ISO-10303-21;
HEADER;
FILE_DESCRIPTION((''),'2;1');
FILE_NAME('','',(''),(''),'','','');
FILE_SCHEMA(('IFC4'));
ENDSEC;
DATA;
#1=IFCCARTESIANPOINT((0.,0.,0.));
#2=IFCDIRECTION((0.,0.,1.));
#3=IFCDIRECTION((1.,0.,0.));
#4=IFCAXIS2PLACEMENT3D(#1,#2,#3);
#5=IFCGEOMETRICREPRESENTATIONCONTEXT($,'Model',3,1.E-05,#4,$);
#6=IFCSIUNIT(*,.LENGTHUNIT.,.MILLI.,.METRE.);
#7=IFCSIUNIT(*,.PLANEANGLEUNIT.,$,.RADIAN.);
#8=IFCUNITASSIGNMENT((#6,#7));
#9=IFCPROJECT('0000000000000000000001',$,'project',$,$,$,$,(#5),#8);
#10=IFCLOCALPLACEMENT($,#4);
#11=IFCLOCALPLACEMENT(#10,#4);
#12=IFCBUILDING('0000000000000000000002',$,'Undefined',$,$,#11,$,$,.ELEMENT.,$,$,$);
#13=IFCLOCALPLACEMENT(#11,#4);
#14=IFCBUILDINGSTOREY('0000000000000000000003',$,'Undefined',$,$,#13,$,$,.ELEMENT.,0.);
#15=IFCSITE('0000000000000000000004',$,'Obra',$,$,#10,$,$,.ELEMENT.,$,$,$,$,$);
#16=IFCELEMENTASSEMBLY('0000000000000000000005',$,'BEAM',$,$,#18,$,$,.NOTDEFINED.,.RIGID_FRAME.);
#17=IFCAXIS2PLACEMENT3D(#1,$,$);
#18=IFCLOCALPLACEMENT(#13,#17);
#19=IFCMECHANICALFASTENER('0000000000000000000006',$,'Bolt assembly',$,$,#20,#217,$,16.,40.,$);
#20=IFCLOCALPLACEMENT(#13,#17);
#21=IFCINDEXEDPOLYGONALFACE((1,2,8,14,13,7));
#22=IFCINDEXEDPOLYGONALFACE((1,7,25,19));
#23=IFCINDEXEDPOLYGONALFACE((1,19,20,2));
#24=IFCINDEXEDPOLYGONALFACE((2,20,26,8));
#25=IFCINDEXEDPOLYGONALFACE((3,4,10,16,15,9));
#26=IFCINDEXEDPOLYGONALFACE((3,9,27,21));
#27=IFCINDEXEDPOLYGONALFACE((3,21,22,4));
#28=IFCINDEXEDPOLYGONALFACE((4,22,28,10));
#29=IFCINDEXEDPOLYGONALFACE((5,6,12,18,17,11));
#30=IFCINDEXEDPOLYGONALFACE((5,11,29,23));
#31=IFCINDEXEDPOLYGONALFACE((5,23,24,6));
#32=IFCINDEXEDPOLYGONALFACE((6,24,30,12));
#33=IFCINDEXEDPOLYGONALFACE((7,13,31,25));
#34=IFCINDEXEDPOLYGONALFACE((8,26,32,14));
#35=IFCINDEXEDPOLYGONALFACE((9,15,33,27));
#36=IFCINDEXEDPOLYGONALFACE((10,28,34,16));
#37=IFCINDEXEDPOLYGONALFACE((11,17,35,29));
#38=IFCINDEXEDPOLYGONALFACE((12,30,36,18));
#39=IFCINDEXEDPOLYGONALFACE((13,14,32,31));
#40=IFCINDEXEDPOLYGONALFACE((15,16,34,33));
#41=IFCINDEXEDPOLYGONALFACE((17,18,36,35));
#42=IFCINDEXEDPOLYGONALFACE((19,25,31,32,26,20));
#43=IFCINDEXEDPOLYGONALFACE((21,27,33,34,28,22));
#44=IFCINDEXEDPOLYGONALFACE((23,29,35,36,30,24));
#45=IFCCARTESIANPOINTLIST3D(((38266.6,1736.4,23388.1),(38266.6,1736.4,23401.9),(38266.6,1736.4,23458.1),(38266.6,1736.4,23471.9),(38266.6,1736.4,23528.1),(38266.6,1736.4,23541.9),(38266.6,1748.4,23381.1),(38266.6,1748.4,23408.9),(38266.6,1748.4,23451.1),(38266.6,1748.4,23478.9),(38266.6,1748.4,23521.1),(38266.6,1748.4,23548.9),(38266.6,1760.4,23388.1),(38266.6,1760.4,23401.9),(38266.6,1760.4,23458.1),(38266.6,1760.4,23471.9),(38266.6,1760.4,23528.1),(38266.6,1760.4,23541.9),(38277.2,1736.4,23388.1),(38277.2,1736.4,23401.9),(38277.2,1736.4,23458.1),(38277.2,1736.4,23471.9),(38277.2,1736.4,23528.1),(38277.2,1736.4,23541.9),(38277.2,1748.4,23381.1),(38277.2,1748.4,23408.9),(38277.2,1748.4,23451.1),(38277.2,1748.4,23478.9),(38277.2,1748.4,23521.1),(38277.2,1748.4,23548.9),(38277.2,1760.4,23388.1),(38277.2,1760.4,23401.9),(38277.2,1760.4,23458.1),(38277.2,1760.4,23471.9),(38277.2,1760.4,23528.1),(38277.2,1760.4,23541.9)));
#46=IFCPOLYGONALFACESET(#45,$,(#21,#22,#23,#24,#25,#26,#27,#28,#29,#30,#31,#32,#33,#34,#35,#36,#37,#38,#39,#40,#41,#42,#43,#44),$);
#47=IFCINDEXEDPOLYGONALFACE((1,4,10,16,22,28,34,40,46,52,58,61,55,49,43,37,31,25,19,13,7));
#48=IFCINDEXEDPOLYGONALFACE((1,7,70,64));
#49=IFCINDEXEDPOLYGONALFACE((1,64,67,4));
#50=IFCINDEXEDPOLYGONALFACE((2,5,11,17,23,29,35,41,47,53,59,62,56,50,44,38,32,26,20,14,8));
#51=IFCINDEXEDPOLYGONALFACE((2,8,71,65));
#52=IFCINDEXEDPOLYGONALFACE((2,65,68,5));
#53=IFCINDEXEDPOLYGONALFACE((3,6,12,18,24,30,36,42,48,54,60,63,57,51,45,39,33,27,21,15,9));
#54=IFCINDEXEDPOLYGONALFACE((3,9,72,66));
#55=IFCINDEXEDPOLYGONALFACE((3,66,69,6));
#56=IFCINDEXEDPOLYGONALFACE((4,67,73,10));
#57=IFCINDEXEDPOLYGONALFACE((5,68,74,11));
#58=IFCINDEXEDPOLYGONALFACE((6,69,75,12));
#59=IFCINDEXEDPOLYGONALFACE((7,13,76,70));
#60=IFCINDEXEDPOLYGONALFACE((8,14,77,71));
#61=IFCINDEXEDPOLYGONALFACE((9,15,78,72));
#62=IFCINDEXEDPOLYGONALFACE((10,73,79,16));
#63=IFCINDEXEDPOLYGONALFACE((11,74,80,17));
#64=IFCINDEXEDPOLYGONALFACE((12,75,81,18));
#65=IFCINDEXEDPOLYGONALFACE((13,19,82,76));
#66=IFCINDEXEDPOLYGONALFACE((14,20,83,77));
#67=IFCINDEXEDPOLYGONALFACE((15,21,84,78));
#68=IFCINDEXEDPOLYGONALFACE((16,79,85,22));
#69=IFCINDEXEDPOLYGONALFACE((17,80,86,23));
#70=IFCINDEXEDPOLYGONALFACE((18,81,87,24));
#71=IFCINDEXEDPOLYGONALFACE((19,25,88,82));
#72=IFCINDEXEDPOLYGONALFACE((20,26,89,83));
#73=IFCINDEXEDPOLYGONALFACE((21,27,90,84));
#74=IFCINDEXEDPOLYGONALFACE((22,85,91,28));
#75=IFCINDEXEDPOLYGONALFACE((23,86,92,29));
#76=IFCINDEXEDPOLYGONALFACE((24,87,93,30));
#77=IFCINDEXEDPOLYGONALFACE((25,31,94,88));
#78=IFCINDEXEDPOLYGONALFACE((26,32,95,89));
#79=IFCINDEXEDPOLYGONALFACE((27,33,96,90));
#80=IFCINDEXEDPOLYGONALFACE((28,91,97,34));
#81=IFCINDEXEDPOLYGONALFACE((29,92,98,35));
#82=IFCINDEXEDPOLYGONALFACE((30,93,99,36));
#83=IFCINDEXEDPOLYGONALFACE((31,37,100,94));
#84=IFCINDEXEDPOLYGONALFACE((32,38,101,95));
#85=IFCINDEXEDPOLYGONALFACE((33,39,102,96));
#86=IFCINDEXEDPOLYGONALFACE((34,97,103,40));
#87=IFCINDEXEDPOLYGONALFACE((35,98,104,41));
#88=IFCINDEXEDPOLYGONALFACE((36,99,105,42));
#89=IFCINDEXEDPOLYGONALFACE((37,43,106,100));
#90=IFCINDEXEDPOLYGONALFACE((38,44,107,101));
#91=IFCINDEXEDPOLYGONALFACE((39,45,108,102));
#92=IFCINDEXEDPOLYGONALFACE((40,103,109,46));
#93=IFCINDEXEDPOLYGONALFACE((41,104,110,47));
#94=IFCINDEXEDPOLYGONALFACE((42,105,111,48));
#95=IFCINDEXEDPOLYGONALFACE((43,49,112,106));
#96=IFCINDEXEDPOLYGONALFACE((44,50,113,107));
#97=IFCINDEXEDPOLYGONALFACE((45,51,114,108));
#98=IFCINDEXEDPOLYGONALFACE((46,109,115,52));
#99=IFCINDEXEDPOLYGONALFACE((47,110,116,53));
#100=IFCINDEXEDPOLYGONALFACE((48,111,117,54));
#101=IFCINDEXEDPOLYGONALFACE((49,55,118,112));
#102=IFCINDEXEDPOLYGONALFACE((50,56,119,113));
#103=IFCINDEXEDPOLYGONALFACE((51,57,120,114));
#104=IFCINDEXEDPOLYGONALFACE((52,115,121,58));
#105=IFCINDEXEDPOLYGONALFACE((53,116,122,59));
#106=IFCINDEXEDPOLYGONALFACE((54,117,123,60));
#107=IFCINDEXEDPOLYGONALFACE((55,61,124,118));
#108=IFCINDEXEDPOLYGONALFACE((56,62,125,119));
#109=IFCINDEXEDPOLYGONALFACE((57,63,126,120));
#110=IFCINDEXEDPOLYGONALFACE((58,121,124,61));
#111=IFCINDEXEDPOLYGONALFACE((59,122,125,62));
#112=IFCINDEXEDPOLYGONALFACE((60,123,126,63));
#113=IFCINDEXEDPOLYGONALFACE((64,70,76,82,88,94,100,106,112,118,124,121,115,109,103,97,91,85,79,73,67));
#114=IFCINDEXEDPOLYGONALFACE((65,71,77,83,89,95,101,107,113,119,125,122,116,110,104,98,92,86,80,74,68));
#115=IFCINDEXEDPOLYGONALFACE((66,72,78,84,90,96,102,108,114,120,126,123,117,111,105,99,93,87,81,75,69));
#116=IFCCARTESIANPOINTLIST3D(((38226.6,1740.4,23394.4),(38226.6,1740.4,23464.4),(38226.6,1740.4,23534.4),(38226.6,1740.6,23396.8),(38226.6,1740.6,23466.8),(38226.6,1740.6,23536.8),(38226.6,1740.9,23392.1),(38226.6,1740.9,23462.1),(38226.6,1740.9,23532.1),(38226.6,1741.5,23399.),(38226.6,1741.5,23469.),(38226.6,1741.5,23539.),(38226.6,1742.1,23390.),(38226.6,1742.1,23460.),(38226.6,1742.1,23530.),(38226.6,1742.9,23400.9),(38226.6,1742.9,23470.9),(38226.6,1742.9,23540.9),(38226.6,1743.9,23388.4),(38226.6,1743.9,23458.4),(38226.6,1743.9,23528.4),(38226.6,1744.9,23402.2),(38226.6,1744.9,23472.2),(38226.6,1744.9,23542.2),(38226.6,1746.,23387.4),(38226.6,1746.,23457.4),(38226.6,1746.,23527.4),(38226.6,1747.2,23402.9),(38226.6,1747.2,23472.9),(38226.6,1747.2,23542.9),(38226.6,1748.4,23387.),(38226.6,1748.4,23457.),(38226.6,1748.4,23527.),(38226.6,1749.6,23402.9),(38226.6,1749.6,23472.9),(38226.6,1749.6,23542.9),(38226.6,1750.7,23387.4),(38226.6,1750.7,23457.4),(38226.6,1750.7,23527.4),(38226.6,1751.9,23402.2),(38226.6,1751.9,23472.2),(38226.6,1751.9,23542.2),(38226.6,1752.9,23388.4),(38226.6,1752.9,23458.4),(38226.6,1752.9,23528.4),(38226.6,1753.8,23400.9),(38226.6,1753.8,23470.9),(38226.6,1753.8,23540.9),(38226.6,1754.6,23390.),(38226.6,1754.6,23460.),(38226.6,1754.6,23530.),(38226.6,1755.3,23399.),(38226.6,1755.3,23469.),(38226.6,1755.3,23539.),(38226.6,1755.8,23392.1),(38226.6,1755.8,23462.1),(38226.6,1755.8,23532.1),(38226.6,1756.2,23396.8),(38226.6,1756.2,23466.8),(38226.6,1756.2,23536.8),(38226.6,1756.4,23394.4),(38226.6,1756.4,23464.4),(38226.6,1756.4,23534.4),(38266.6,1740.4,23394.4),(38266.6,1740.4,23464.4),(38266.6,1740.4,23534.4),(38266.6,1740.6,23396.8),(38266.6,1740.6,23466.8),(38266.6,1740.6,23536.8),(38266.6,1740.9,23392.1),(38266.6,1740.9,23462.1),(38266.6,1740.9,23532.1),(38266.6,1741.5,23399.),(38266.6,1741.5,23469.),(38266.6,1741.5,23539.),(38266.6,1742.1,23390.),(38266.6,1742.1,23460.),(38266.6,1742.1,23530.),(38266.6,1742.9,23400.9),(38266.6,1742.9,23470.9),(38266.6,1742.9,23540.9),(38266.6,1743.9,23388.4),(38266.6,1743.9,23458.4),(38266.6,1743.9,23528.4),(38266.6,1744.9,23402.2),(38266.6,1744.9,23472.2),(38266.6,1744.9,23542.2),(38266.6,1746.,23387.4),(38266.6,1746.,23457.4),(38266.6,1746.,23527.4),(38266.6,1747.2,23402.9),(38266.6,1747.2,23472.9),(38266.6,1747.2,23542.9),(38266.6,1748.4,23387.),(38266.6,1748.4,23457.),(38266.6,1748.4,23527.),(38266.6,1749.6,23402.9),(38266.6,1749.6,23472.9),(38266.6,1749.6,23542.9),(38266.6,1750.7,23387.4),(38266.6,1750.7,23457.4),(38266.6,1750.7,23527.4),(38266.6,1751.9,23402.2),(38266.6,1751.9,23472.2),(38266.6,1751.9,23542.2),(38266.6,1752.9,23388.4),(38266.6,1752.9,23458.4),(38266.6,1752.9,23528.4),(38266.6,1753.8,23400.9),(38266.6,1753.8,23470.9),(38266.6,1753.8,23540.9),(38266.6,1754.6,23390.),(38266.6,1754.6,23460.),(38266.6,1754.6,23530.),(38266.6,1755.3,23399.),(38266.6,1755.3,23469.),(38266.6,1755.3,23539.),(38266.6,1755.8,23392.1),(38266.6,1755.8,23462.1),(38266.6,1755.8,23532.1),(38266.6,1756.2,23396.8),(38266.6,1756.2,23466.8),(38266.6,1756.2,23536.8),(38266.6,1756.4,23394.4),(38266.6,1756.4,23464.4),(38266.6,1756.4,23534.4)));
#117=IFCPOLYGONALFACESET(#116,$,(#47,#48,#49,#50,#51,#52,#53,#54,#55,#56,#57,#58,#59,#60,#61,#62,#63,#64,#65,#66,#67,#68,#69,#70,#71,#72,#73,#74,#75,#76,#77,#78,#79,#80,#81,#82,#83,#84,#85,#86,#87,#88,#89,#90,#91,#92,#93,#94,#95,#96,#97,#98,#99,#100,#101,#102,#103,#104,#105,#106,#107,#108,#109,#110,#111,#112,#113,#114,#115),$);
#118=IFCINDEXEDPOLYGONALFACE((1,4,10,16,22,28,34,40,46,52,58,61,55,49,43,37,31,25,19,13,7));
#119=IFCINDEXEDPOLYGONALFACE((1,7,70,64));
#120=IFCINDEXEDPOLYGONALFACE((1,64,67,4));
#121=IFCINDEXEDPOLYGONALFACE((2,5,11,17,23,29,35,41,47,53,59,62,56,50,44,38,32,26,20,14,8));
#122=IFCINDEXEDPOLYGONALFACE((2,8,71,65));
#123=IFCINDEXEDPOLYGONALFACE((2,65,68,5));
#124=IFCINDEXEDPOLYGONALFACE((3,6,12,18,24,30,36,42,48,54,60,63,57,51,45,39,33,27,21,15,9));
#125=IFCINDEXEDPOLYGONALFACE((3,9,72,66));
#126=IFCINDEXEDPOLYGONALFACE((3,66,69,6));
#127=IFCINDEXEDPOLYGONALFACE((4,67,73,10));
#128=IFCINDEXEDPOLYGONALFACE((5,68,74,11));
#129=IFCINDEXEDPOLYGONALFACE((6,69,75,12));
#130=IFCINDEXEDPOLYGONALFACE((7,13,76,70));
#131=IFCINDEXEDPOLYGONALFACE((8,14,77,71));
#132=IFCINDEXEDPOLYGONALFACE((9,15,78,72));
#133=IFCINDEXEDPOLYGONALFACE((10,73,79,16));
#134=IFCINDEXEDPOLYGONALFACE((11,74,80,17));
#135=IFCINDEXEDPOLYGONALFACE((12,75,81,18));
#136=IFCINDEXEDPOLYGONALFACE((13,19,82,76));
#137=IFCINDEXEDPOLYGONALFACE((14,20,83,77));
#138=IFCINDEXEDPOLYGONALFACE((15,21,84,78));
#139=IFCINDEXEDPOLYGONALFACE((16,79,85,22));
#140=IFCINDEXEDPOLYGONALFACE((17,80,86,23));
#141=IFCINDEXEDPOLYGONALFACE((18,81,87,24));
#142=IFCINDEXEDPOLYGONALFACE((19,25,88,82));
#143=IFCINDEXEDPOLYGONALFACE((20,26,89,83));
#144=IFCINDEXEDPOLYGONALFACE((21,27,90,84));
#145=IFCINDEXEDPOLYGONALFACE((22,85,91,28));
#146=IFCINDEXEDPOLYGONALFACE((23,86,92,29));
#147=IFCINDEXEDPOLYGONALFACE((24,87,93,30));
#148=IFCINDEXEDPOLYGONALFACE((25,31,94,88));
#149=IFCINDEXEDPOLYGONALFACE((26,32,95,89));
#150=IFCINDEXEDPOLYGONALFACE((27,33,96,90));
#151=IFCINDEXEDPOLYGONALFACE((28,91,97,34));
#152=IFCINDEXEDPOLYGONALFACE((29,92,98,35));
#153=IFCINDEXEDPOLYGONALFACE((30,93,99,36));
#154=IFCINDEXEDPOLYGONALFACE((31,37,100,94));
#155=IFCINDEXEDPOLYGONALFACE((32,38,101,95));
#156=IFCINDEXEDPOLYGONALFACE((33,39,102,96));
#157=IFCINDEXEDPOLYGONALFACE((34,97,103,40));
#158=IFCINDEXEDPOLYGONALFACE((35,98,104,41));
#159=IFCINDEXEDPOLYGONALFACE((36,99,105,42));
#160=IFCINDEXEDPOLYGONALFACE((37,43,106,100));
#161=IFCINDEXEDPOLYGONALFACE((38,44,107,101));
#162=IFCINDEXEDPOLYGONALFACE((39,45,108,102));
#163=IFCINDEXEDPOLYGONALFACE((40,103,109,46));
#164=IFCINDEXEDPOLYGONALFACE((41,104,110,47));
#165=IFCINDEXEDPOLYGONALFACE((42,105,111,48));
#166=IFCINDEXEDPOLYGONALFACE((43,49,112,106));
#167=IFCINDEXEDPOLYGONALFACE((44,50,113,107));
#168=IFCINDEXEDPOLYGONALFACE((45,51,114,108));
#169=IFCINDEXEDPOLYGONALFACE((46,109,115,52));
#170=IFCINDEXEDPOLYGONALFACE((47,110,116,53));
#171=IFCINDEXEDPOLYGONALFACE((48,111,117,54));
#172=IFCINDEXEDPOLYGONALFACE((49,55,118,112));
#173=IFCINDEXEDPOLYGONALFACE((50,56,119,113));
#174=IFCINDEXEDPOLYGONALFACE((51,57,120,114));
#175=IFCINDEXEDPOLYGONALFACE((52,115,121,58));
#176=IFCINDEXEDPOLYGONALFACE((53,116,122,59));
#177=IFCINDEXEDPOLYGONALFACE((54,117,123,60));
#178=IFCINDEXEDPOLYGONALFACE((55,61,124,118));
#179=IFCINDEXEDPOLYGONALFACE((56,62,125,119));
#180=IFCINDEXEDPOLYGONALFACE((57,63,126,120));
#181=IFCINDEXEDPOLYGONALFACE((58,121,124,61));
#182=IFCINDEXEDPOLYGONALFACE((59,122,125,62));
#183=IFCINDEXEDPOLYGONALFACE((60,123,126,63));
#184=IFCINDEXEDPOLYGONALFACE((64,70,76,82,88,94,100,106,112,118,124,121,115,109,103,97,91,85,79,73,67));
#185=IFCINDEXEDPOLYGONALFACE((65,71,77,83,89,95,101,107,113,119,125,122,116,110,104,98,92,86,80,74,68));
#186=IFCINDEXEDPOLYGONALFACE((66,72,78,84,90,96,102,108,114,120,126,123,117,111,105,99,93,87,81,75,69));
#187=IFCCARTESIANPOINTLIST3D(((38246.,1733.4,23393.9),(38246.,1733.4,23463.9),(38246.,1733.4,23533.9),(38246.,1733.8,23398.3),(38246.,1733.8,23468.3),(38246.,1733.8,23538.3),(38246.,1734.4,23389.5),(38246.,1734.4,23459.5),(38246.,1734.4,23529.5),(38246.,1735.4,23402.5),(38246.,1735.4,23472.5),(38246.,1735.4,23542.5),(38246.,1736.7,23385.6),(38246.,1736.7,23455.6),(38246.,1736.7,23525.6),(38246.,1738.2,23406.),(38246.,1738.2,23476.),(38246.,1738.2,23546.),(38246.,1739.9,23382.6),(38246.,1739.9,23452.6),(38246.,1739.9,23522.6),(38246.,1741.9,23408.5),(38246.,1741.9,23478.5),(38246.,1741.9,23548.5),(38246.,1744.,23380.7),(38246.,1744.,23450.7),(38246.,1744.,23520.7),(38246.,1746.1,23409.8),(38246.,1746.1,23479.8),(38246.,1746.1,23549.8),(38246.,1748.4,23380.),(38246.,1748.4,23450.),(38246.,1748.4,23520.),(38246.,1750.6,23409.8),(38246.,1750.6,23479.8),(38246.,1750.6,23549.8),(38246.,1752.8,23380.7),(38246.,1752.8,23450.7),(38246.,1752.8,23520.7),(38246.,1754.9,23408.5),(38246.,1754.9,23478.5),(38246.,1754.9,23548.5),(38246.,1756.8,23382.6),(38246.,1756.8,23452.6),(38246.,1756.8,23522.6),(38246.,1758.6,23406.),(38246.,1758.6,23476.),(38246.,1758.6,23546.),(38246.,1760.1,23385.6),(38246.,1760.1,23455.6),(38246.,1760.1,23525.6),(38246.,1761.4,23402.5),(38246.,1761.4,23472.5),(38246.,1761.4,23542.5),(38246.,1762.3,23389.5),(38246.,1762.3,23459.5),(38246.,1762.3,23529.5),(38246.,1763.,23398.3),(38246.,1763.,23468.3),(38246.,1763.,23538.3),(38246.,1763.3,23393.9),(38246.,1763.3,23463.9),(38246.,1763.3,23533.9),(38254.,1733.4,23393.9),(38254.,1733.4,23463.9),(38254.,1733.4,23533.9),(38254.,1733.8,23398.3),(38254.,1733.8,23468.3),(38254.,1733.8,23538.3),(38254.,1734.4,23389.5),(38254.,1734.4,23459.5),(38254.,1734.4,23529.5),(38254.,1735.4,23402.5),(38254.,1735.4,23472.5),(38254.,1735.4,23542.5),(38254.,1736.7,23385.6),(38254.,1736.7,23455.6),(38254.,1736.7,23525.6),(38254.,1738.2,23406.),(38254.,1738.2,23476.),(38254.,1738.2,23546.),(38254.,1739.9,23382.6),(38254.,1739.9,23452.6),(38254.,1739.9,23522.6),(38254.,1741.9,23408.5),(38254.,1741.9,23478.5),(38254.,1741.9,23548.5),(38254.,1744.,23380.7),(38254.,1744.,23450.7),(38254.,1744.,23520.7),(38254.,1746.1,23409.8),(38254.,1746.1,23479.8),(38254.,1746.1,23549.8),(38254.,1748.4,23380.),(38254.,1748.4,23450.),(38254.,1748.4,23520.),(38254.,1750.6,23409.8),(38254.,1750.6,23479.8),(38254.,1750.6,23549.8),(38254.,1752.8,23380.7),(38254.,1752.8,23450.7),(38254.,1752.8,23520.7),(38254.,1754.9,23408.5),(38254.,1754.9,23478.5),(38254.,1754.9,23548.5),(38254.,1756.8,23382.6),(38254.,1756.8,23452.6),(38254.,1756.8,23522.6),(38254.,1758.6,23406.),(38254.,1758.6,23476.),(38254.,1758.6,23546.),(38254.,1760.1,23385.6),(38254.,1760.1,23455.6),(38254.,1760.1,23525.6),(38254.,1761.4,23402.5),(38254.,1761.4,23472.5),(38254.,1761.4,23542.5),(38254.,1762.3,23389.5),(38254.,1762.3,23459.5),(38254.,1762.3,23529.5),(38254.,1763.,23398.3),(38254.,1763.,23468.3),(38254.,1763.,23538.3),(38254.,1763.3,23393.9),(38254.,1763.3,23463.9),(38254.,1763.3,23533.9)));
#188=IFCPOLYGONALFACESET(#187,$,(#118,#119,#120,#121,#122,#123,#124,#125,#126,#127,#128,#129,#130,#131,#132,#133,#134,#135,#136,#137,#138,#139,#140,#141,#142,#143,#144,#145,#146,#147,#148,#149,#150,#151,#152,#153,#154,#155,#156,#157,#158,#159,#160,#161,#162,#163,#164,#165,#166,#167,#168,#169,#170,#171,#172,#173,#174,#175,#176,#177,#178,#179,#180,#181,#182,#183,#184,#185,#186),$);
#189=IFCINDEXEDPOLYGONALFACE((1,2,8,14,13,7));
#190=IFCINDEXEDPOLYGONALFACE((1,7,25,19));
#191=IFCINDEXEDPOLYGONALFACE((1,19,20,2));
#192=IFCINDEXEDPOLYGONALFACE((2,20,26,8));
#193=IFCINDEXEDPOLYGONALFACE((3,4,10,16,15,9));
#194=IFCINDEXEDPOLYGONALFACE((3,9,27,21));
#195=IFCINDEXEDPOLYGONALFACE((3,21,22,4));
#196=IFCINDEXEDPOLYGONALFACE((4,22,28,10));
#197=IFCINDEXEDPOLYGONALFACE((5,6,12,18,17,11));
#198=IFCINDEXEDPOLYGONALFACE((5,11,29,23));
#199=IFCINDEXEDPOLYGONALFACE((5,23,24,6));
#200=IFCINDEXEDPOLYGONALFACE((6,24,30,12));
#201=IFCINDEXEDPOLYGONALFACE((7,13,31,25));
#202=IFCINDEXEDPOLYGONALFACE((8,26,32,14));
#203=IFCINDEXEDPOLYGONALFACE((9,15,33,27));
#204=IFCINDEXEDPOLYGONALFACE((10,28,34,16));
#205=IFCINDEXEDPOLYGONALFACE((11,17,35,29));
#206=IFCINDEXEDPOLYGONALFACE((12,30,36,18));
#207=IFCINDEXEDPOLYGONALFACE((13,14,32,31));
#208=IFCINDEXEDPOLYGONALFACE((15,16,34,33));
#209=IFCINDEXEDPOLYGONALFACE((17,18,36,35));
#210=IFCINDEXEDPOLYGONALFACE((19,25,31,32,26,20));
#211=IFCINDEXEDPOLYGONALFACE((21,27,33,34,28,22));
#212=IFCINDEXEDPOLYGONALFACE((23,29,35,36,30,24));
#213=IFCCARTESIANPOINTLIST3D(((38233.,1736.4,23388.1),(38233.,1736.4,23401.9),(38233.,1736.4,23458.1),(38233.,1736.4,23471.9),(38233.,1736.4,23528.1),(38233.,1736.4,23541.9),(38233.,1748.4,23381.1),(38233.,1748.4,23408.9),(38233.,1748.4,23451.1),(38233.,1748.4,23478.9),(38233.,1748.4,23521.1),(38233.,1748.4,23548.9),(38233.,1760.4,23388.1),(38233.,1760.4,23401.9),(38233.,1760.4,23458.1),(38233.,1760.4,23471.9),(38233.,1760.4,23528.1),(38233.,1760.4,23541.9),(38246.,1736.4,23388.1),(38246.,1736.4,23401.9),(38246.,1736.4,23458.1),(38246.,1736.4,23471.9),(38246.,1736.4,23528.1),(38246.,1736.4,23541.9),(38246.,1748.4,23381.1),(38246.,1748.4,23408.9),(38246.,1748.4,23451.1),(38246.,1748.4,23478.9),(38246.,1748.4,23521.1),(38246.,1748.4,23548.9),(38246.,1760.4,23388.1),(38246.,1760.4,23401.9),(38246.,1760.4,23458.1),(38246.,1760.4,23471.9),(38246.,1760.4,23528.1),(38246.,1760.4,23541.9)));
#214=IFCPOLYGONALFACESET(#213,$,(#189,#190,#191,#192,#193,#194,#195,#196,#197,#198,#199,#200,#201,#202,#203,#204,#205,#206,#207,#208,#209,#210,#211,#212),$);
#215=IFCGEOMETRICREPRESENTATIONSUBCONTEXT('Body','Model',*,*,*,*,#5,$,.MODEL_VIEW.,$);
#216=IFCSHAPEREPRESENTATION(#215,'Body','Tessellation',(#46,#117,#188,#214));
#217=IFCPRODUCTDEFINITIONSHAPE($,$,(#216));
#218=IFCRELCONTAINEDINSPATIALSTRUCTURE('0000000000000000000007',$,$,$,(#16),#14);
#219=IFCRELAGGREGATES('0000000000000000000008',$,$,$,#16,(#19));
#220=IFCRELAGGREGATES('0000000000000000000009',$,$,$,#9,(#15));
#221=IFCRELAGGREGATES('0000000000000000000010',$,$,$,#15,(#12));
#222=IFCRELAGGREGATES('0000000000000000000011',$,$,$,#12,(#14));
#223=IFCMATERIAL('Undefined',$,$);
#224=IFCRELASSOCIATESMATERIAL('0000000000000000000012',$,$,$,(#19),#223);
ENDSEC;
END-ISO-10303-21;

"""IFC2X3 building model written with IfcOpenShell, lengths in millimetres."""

from ifc_helpers import new_model, si_unit, frame, origin_with_axes, origin_2d_with_axis, place, context, subcontext, project, spatial, polyline, circle, outline, extrude, source, transform, mapped, material, element, aggregate, save


model = new_model("IFC2X3")

# Units and contexts
model_context = context("Model", 3, precision=1e-05, world=origin_with_axes())
body_context = subcontext(model_context, "Body", "Model", "MODEL_VIEW")
ifc_project = project(units=[si_unit("LENGTHUNIT", "METRE", prefix="MILLI"), si_unit("PLANEANGLEUNIT", "RADIAN")], contexts=[model_context])

# Site, building, storey
site_placement = place(None, origin_with_axes())
site = spatial("IfcSite", under=ifc_project, at=site_placement, Name="Obra", CompositionType="ELEMENT")
building_placement = place(site_placement, origin_with_axes())
building = spatial("IfcBuilding", under=site, at=building_placement, Name="Undefined", CompositionType="ELEMENT")
storey_placement = place(building_placement, origin_with_axes())
storey = spatial("IfcBuildingStorey", under=building, at=storey_placement, Name="Undefined", CompositionType="ELEMENT", Elevation=0.0)

# Element assembly
assembly_1_placement = place(storey_placement, origin_with_axes())
assembly_1 = element("IfcElementAssembly", 1, at=assembly_1_placement, inside=storey, Name="BEAM", AssemblyPlace="NOTDEFINED", PredefinedType="RIGID_FRAME")

# Shared definitions
ifc_material_1 = material(Name="Undefined")

# Mechanical fastener
shared_shape_1 = source(origin_with_axes(), body_context, "Body", "SweptSolid", [
    extrude(outline(polyline([(13.9, 0.0), (6.9, 12.0), (-6.9, 12.0), (-13.9, 0.0), (-6.9, -12.0), (6.9, -12.0), (13.9, 0.0)])), frame((0.0, -13.9, 0.0), z_axis=(0.0, 1.0, 0.0), x_axis=(1.0, 0.0, 0.0)), (0.0, 0.0, 1.0), 10.6),
    extrude(circle(Radius=8.0, at=origin_2d_with_axis()), frame((0.0, -3.3, 0.0), z_axis=(0.0, 1.0, 0.0), x_axis=(1.0, 0.0, 0.0)), (0.0, 0.0, 1.0), 40.0),
    extrude(circle(Radius=15.0, at=origin_2d_with_axis()), frame((0.0, 9.3, 0.0), z_axis=(0.0, 1.0, 0.0), x_axis=(1.0, 0.0, 0.0)), (0.0, 0.0, 1.0), 8.0),
    extrude(outline(polyline([(13.9, 0.0), (6.9, 12.0), (-6.9, 12.0), (-13.9, 0.0), (-6.9, -12.0), (6.9, -12.0), (13.9, 0.0)])), frame((0.0, 17.3, 0.0), z_axis=(0.0, 1.0, 0.0), x_axis=(1.0, 0.0, 0.0)), (0.0, 0.0, 1.0), 13.0),
])
mechanical_fastener_1_placement = place(assembly_1_placement, frame((38263.3, 1708.4, 23570.0), z_axis=(0.0, 1.0, 0.0), x_axis=(0.0, 0.0, -1.0)))
mechanical_fastener_1 = element("IfcMechanicalFastener", 2, at=mechanical_fastener_1_placement, material=ifc_material_1, Name="Bolt assembly", NominalDiameter=16.0, NominalLength=40.0, context=body_context, shape_type="MappedRepresentation", body=[
    mapped(shared_shape_1, transform((35.0, 0.0, 40.0))),
    mapped(shared_shape_1, transform((105.0, 0.0, 40.0))),
    mapped(shared_shape_1, transform((175.0, 0.0, 40.0))),
])

aggregate(assembly_1, [mechanical_fastener_1])

save(model, "model.ifc")
